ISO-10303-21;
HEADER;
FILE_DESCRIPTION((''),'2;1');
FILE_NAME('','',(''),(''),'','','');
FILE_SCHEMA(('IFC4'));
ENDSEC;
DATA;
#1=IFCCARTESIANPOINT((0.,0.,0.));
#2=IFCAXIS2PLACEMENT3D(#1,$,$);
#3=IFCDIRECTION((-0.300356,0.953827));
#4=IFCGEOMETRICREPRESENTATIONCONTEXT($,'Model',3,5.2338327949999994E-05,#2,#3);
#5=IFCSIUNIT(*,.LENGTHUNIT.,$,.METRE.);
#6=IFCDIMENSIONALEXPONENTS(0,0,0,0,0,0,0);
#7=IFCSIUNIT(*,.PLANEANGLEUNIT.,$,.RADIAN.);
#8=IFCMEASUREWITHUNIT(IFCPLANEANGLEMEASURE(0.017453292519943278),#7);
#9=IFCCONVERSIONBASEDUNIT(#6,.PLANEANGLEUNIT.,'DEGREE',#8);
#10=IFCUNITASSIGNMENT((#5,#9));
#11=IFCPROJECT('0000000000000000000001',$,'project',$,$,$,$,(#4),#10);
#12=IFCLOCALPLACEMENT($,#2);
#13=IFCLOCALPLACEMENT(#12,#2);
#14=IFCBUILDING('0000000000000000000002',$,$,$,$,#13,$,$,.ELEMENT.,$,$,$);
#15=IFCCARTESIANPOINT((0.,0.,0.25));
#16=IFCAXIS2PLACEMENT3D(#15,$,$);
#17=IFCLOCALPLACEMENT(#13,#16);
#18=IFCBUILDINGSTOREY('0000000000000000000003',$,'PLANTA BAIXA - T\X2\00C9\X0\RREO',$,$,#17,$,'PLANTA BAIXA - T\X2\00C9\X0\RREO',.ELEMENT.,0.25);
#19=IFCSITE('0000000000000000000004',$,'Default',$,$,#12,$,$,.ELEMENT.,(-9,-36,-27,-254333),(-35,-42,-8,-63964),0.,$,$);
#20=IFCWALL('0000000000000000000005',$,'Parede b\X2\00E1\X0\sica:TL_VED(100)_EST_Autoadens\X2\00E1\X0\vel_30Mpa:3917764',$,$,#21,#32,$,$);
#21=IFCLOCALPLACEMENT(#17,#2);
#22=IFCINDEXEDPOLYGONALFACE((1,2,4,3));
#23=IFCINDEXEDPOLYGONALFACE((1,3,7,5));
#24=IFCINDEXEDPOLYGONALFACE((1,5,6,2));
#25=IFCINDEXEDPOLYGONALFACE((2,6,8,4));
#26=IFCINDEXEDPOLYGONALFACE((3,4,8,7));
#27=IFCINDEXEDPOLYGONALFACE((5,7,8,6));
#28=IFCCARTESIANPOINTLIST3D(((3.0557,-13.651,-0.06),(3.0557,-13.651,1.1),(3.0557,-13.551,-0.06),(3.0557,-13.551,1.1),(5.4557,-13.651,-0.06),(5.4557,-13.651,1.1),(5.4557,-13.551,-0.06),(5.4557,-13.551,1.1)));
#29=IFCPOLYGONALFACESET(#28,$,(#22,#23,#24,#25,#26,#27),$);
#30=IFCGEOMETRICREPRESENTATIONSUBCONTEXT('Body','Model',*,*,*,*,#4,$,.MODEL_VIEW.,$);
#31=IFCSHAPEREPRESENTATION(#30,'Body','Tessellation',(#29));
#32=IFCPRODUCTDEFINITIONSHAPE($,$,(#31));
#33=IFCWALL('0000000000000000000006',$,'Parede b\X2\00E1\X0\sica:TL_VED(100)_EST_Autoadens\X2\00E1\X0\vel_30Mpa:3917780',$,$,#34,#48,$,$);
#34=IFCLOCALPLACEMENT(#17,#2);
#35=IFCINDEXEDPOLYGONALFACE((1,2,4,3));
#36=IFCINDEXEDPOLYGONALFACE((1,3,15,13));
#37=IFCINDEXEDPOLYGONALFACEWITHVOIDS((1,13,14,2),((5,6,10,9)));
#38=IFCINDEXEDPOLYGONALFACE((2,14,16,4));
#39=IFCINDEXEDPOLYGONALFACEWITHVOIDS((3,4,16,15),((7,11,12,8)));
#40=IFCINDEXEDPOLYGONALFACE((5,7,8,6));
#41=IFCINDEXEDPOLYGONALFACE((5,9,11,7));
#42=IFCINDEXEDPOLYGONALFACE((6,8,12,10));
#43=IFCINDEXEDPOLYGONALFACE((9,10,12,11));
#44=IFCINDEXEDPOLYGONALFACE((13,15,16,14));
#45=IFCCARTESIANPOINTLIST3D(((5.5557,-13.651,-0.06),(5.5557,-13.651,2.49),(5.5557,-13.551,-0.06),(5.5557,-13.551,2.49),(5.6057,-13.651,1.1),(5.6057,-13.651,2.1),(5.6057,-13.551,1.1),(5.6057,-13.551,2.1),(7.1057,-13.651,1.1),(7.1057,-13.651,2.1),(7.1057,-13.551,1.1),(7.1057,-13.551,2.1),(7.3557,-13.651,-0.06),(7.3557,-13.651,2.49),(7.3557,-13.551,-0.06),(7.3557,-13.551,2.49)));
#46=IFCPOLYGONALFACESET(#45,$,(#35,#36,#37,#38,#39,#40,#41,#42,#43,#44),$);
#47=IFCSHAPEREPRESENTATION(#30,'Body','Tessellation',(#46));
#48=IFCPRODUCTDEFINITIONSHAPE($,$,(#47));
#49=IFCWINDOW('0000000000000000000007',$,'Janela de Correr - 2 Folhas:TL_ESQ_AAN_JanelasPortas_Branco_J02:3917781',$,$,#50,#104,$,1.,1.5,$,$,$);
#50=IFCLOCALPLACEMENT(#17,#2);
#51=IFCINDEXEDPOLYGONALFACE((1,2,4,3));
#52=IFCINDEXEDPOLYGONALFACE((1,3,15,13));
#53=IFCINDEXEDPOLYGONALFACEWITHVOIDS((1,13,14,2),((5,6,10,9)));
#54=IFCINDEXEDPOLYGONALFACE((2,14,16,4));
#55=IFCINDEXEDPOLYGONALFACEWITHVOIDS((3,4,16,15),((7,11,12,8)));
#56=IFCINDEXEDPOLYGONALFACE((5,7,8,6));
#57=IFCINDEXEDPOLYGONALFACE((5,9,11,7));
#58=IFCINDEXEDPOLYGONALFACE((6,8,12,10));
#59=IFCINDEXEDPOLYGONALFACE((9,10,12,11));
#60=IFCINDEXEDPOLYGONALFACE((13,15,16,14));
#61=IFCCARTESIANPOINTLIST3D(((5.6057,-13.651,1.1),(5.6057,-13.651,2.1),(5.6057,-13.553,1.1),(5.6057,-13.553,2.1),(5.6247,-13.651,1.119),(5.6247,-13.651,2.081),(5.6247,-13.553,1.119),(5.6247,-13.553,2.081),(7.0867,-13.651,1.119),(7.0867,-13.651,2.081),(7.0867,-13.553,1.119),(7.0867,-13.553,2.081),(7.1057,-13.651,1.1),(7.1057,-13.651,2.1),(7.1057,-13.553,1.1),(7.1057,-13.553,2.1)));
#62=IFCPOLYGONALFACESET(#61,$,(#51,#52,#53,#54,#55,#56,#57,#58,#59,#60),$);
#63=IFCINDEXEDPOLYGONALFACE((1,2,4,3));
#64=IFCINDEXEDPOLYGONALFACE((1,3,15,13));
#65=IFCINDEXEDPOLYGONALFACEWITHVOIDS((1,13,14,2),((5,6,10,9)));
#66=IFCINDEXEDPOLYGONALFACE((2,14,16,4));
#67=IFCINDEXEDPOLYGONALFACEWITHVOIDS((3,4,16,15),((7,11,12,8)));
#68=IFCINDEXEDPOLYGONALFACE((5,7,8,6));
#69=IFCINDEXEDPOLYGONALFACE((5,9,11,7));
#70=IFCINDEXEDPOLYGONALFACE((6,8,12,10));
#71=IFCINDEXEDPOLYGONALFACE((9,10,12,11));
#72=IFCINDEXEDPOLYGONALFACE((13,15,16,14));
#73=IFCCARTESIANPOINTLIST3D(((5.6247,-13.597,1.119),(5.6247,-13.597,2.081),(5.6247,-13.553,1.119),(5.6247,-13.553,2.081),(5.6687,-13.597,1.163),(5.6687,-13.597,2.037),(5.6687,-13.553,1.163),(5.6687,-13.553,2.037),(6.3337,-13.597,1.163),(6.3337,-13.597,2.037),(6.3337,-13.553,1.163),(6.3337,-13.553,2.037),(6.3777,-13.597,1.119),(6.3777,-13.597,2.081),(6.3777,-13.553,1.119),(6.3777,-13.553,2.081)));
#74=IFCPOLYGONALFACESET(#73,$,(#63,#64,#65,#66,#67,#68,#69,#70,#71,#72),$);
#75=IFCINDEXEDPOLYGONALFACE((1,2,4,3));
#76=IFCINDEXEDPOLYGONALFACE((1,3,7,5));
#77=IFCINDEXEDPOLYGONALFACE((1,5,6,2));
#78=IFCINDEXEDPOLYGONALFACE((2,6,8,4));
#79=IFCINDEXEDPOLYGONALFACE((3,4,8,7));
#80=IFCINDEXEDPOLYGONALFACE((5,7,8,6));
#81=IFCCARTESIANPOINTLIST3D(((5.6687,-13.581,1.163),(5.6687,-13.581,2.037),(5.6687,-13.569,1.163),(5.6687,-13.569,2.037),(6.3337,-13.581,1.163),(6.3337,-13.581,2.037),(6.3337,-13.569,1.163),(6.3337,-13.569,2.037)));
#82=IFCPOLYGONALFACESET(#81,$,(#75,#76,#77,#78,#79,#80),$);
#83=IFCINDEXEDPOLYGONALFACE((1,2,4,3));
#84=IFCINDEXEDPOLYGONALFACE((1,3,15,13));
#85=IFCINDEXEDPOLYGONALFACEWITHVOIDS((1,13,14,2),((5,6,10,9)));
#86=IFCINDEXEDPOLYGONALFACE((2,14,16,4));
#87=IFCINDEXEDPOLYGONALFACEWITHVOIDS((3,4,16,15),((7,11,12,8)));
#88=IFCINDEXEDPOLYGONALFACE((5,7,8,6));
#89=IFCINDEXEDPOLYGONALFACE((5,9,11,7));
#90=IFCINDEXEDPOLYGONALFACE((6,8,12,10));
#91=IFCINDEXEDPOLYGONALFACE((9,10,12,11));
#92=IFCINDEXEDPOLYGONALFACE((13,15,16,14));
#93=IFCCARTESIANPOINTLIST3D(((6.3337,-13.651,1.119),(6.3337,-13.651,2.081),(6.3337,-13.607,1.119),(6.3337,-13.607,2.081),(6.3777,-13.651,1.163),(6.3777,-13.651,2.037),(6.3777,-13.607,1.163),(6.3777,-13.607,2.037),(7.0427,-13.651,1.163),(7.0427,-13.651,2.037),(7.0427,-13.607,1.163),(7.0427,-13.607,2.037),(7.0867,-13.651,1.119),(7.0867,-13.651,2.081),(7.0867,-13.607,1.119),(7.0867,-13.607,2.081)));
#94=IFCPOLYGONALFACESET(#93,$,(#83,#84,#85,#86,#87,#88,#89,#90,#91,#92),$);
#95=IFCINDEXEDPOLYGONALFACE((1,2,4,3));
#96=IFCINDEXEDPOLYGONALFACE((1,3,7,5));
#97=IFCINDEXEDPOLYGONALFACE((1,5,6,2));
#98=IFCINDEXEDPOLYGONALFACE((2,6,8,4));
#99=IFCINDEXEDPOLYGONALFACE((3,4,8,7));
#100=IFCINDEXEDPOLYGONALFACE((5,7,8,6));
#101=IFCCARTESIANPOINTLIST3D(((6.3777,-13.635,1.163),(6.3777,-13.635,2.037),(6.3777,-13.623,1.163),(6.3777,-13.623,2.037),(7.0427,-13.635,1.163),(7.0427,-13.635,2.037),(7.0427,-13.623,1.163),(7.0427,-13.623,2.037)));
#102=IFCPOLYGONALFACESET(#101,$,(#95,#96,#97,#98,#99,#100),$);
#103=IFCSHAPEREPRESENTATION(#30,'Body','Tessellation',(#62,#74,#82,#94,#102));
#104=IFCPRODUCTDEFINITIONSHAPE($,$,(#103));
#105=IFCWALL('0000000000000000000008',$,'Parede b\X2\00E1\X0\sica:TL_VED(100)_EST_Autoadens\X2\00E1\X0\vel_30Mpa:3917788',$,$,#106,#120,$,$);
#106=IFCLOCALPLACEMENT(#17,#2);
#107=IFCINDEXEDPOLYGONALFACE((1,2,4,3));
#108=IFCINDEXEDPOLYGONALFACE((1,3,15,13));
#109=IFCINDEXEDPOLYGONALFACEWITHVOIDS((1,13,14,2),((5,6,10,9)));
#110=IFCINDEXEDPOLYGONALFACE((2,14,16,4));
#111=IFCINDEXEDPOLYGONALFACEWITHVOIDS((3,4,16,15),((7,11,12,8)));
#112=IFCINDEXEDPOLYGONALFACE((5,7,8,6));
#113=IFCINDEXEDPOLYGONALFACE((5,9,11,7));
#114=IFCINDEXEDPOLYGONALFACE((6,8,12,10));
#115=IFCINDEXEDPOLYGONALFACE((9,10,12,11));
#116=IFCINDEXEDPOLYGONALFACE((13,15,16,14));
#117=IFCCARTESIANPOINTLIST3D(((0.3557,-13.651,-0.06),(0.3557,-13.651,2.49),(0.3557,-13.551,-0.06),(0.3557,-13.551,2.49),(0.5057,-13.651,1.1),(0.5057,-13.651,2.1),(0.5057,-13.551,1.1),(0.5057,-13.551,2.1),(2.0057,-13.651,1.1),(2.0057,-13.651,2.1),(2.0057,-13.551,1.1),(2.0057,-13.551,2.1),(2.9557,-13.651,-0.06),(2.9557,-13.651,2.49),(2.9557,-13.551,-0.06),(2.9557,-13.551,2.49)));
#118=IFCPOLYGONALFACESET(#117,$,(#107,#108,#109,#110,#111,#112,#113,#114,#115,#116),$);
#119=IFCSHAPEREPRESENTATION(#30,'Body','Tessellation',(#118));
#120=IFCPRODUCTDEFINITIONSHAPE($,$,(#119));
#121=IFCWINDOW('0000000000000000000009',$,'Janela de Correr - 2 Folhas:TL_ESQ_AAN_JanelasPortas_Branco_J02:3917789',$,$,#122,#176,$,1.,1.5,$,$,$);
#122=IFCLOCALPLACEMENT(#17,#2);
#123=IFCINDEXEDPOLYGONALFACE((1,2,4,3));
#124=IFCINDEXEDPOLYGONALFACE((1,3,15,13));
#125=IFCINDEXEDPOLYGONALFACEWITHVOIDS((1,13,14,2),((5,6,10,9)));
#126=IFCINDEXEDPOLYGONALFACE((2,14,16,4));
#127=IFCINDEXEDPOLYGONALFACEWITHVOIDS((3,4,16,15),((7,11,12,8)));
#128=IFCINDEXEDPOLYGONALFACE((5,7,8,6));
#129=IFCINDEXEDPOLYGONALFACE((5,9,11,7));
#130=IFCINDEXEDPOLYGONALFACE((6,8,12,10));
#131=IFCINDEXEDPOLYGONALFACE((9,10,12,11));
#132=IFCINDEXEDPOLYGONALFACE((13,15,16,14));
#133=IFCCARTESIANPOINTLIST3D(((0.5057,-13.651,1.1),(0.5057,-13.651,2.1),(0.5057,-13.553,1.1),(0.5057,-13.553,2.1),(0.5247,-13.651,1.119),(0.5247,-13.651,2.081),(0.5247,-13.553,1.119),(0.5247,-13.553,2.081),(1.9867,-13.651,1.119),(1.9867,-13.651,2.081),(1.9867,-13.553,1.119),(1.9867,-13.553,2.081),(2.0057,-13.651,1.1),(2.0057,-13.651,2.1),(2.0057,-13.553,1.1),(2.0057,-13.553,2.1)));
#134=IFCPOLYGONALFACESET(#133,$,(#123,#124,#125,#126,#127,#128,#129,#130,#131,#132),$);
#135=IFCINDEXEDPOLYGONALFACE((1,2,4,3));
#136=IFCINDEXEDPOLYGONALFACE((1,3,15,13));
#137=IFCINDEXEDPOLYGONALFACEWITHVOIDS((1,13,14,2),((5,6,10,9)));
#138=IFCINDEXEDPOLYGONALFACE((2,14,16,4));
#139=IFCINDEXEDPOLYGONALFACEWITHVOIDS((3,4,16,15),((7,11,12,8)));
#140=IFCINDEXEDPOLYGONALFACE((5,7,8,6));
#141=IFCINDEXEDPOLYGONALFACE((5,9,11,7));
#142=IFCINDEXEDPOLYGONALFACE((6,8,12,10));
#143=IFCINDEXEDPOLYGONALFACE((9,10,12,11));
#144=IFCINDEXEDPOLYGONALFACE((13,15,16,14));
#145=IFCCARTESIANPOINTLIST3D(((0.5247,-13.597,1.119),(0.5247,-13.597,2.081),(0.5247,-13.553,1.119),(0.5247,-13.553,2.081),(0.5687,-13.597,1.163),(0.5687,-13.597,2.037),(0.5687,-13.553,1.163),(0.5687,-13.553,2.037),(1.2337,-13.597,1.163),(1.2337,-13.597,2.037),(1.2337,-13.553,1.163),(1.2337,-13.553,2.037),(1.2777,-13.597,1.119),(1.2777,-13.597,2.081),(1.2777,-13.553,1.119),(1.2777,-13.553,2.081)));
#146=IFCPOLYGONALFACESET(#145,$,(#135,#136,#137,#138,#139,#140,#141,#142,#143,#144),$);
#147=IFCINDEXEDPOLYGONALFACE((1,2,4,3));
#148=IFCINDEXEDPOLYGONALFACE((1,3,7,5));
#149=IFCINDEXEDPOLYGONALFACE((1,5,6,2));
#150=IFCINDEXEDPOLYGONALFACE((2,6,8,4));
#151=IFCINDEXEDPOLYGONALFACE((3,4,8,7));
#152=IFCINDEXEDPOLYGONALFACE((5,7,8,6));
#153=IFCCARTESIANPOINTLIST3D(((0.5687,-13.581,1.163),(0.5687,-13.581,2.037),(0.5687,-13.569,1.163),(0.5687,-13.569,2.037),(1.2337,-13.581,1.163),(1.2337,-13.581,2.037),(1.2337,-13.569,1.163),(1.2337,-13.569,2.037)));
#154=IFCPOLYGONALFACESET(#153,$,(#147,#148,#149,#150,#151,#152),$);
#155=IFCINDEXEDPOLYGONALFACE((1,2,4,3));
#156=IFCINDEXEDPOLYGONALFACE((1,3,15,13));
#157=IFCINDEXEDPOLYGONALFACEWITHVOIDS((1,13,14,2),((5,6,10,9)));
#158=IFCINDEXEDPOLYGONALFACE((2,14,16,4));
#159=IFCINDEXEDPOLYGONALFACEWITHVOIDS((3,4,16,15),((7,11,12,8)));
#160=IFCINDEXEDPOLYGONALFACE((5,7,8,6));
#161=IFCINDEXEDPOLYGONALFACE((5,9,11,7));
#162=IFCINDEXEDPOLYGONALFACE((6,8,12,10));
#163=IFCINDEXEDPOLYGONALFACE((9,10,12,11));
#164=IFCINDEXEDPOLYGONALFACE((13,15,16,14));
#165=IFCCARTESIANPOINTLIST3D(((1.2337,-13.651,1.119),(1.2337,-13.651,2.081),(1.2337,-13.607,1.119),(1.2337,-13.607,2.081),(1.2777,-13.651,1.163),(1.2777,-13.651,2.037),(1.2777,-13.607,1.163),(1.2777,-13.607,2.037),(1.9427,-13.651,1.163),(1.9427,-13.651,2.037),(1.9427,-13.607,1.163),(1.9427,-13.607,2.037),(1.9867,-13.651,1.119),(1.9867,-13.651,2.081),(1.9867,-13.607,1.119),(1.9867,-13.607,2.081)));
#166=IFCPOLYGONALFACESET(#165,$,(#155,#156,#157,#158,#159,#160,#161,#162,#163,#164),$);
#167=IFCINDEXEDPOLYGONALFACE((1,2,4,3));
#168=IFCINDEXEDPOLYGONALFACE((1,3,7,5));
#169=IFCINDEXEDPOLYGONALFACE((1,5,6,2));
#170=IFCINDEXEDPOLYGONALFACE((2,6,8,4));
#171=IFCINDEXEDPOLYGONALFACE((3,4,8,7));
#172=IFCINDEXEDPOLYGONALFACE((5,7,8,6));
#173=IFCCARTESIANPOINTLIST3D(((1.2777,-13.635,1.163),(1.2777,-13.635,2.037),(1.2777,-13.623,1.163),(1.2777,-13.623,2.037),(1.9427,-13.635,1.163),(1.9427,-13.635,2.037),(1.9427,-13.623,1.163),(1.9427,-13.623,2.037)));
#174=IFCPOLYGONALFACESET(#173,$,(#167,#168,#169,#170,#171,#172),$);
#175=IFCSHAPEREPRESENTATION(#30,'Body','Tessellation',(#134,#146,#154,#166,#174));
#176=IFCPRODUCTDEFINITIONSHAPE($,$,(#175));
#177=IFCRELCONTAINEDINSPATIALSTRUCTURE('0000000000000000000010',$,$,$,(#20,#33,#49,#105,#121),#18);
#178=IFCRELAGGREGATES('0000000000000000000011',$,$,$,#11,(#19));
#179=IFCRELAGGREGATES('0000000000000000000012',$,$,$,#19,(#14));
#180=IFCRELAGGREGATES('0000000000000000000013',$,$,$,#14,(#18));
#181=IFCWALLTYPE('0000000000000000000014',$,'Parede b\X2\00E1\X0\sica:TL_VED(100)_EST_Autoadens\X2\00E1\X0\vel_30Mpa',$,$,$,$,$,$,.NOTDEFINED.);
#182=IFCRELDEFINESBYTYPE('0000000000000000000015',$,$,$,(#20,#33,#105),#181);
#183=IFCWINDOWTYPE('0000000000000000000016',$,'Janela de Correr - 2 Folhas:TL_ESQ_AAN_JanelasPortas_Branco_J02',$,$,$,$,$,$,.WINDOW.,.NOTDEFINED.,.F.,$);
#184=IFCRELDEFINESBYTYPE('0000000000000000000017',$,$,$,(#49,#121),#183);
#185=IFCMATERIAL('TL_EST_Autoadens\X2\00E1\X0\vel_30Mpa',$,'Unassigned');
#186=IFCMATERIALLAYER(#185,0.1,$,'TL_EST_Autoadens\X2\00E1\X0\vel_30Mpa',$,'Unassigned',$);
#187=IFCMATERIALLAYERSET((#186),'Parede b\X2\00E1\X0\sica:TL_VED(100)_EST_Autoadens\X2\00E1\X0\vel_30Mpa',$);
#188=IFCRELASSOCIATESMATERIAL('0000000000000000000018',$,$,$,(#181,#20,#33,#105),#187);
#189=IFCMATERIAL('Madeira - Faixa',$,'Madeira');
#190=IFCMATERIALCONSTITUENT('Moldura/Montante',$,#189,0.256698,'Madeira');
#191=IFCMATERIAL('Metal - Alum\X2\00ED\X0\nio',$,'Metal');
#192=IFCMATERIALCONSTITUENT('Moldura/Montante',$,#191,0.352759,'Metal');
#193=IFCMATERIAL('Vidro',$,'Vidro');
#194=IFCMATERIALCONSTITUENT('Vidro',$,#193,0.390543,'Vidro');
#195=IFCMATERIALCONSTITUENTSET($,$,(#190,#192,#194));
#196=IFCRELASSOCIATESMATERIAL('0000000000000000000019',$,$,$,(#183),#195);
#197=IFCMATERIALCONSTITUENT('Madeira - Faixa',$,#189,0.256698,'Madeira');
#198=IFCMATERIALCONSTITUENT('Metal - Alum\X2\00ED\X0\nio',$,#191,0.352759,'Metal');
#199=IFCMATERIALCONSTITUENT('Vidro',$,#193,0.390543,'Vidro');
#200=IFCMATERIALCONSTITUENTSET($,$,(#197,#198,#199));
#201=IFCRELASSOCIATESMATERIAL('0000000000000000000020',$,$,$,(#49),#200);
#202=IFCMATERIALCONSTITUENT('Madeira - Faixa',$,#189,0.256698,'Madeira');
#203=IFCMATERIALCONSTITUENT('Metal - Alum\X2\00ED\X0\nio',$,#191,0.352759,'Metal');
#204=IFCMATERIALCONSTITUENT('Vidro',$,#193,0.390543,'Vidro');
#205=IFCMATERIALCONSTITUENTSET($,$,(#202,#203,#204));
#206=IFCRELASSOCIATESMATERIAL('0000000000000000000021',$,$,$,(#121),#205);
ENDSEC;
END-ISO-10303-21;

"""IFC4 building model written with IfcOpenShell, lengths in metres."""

from ifc_helpers import new_model, entity, si_unit, converted_unit, direction, frame, frame_2d, origin, origin_2d_with_axis, place, context, subcontext, project, spatial, polyline, rectangle, outline, extrude, source, transform, mapped, material, layer, layer_set, layer_usage, constituent, constituent_set, type_object, type_shapes, element, fill, save


model = new_model("IFC4")

# Units and contexts
model_context = context("Model", 3, precision=5.2338327949999994e-05, world=origin(), true_north=direction((-0.300356, 0.953827)))
body_context = subcontext(model_context, "Body", "Model", "MODEL_VIEW")
ifc_project = project(units=[si_unit("LENGTHUNIT", "METRE"), converted_unit("PLANEANGLEUNIT", "DEGREE", entity("IfcPlaneAngleMeasure", 0.017453292519943278), si_unit("PLANEANGLEUNIT", "RADIAN"), dimensions=[0, 0, 0, 0, 0, 0, 0])], contexts=[model_context])

# Site, building, storey
site_placement = place(None, origin())
site = spatial("IfcSite", under=ifc_project, at=site_placement, Name="Default", CompositionType="ELEMENT", RefLatitude=(-9, -36, -27, -254333), RefLongitude=(-35, -42, -8, -63964), RefElevation=0.0)
building_placement = place(site_placement, origin())
building = spatial("IfcBuilding", under=site, at=building_placement, CompositionType="ELEMENT")
storey_placement = place(building_placement, frame((0.0, 0.0, 0.25)))
storey = spatial("IfcBuildingStorey", under=building, at=storey_placement, Name="PLANTA BAIXA - TÉRREO", LongName="PLANTA BAIXA - TÉRREO", CompositionType="ELEMENT", Elevation=0.25)

# Wall
ifc_material_1 = material(Name="TL_EST_Autoadensável_30Mpa", Category="Unassigned")
ifc_layer_1 = layer(ifc_material_1, 0.1, Name="TL_EST_Autoadensável_30Mpa", Category="Unassigned")
ifc_layer_set_1 = layer_set([ifc_layer_1], Name="Parede básica:TL_VED(100)_EST_Autoadensável_30Mpa")
ifc_layer_usage_1 = layer_usage(ifc_layer_set_1, "AXIS2", "NEGATIVE", 0.05)
wall_type_1 = type_object("IfcWallType", Name="Parede básica:TL_VED(100)_EST_Autoadensável_30Mpa", PredefinedType="NOTDEFINED", material=ifc_layer_set_1)
wall_1_placement = place(storey_placement, frame((3.0557, -13.601, -0.06)))
element("IfcWall", 1, at=wall_1_placement, inside=storey, type_object=wall_type_1, material=ifc_layer_usage_1, Name="Parede básica:TL_VED(100)_EST_Autoadensável_30Mpa:3917764", context=body_context, shape_type="SweptSolid", body=[
    extrude(rectangle(XDim=2.4, YDim=0.1, at=frame_2d((1.2, 0.0), x_axis=(-1.0, 0.0))), origin(), (0.0, 0.0, 1.0), 1.16),
])

# Walls, openings, windows
ifc_layer_usage_2 = layer_usage(ifc_layer_set_1, "AXIS2", "NEGATIVE", 0.05)
wall_2_placement = place(storey_placement, frame((5.5557, -13.601, -0.06)))
wall_2 = element("IfcWall", 2, at=wall_2_placement, inside=storey, type_object=wall_type_1, material=ifc_layer_usage_2, Name="Parede básica:TL_VED(100)_EST_Autoadensável_30Mpa:3917780", context=body_context, shape_type="SweptSolid", body=[
    extrude(rectangle(XDim=1.8, YDim=0.1, at=frame_2d((0.9, 0.0), x_axis=(-1.0, 0.0))), origin(), (0.0, 0.0, 1.0), 2.55),
])
opening_1_placement = place(wall_2_placement, frame((0.05, -0.05, 1.16)))
opening_1 = element("IfcOpeningElement", 3, at=opening_1_placement, cuts=wall_2, PredefinedType="OPENING", context=body_context, shape_type="SweptSolid", body=[
    extrude(rectangle(XDim=1.0, YDim=1.5, at=frame_2d((0.5, 0.75), x_axis=(-1.0, 0.0))), frame((0.0, 0.0, 0.0), z_axis=(0.0, 1.0, 0.0), x_axis=(0.0, 0.0, 1.0)), (0.0, 0.0, 1.0), 0.1),
])
ifc_material_2 = material(Name="Madeira - Faixa", Category="Madeira")
ifc_constituent_1 = constituent(ifc_material_2, Name="Madeira - Faixa", Category="Madeira", fraction=0.256698)
ifc_material_3 = material(Name="Metal - Alumínio", Category="Metal")
ifc_constituent_2 = constituent(ifc_material_3, Name="Metal - Alumínio", Category="Metal", fraction=0.352759)
ifc_material_4 = material(Name="Vidro", Category="Vidro")
ifc_constituent_3 = constituent(ifc_material_4, Name="Vidro", Category="Vidro", fraction=0.390543)
ifc_constituent_set_1 = constituent_set(constituents=[ifc_constituent_1, ifc_constituent_2, ifc_constituent_3])
ifc_constituent_4 = constituent(ifc_material_2, Name="Moldura/Montante", Category="Madeira", fraction=0.256698)
ifc_constituent_5 = constituent(ifc_material_3, Name="Moldura/Montante", Category="Metal", fraction=0.352759)
ifc_constituent_6 = constituent(ifc_material_4, Name="Vidro", Category="Vidro", fraction=0.390543)
ifc_constituent_set_2 = constituent_set(constituents=[ifc_constituent_4, ifc_constituent_5, ifc_constituent_6])
window_type = type_object("IfcWindowType", Name="Janela de Correr - 2 Folhas:TL_ESQ_AAN_JanelasPortas_Branco_J02", ParameterTakesPrecedence=False, PartitioningType="NOTDEFINED", PredefinedType="WINDOW", material=ifc_constituent_set_2)
shared_shape_1 = source(origin(), body_context, "Body", "SweptSolid", [
    extrude(outline(polyline([(-0.75, -0.5), (0.75, -0.5), (0.75, 0.5), (-0.75, 0.5), (-0.75, -0.5)]), holes=[polyline([(-0.731, -0.481), (-0.731, 0.481), (0.731, 0.481), (0.731, -0.481), (-0.731, -0.481)])]), frame((0.75, 0.124, 0.5), z_axis=(0.0, -1.0, 0.0), x_axis=(-1.0, 0.0, 0.0)), (0.0, 0.0, 1.0), 0.098),
    extrude(outline(polyline([(-0.3765, -0.481), (0.3765, -0.481), (0.3765, 0.481), (-0.3765, 0.481), (-0.3765, -0.481)]), holes=[polyline([(-0.3325, -0.437), (-0.3325, 0.437), (0.3325, 0.437), (0.3325, -0.437), (-0.3325, -0.437)])]), frame((0.3955, 0.124, 0.5), z_axis=(0.0, -1.0, 0.0), x_axis=(-1.0, 0.0, 0.0)), (0.0, 0.0, 1.0), 0.044),
    extrude(rectangle(XDim=0.665, YDim=0.012, at=origin_2d_with_axis()), frame((0.3955, 0.102, 0.063), z_axis=(0.0, 0.0, 1.0), x_axis=(-1.0, 0.0, 0.0)), (0.0, 0.0, 1.0), 0.874),
    extrude(outline(polyline([(-0.481, -0.3765), (0.481, -0.3765), (0.481, 0.3765), (-0.481, 0.3765), (-0.481, -0.3765)]), holes=[polyline([(-0.437, -0.3325), (-0.437, 0.3325), (0.437, 0.3325), (0.437, -0.3325), (-0.437, -0.3325)])]), frame((1.1045, 0.07, 0.5), z_axis=(0.0, -1.0, 0.0), x_axis=(0.0, 0.0, -1.0)), (0.0, 0.0, 1.0), 0.044),
    extrude(rectangle(XDim=0.665, YDim=0.012, at=origin_2d_with_axis()), frame((1.1045, 0.048, 0.063), z_axis=(0.0, 0.0, 1.0), x_axis=(-1.0, 0.0, 0.0)), (0.0, 0.0, 1.0), 0.874),
])
type_shapes(window_type, [shared_shape_1])
window_1_placement = place(opening_1_placement, frame((0.0, -0.026, 0.0)))
window_1 = element("IfcWindow", 4, at=window_1_placement, inside=storey, type_object=window_type, material=ifc_constituent_set_1, Name="Janela de Correr - 2 Folhas:TL_ESQ_AAN_JanelasPortas_Branco_J02:3917781", OverallHeight=1.0, OverallWidth=1.5, context=body_context, shape_type="MappedRepresentation", body=[
    mapped(shared_shape_1, transform((0.0, 0.0, 0.0), scale=1.0)),
])
fill(opening_1, window_1)
ifc_layer_usage_3 = layer_usage(ifc_layer_set_1, "AXIS2", "NEGATIVE", 0.05)
wall_3_placement = place(storey_placement, frame((0.3557, -13.601, -0.06)))
wall_3 = element("IfcWall", 5, at=wall_3_placement, inside=storey, type_object=wall_type_1, material=ifc_layer_usage_3, Name="Parede básica:TL_VED(100)_EST_Autoadensável_30Mpa:3917788", context=body_context, shape_type="SweptSolid", body=[
    extrude(rectangle(XDim=2.6, YDim=0.1, at=frame_2d((1.3, 0.0), x_axis=(-1.0, 0.0))), origin(), (0.0, 0.0, 1.0), 2.55),
])
opening_2_placement = place(wall_3_placement, frame((0.15, -0.05, 1.16)))
opening_2 = element("IfcOpeningElement", 6, at=opening_2_placement, cuts=wall_3, PredefinedType="OPENING", context=body_context, shape_type="SweptSolid", body=[
    extrude(rectangle(XDim=1.0, YDim=1.5, at=frame_2d((0.5, 0.75), x_axis=(-1.0, 0.0))), frame((0.0, 0.0, 0.0), z_axis=(0.0, 1.0, 0.0), x_axis=(0.0, 0.0, 1.0)), (0.0, 0.0, 1.0), 0.1),
])
ifc_constituent_7 = constituent(ifc_material_2, Name="Madeira - Faixa", Category="Madeira", fraction=0.256698)
ifc_constituent_8 = constituent(ifc_material_3, Name="Metal - Alumínio", Category="Metal", fraction=0.352759)
ifc_constituent_9 = constituent(ifc_material_4, Name="Vidro", Category="Vidro", fraction=0.390543)
ifc_constituent_set_3 = constituent_set(constituents=[ifc_constituent_7, ifc_constituent_8, ifc_constituent_9])
window_2_placement = place(opening_2_placement, frame((0.0, -0.026, 0.0)))
window_2 = element("IfcWindow", 7, at=window_2_placement, inside=storey, type_object=window_type, material=ifc_constituent_set_3, Name="Janela de Correr - 2 Folhas:TL_ESQ_AAN_JanelasPortas_Branco_J02:3917789", OverallHeight=1.0, OverallWidth=1.5, context=body_context, shape_type="MappedRepresentation", body=[
    mapped(shared_shape_1, transform((0.0, 0.0, 0.0), scale=1.0)),
])
fill(opening_2, window_2)

save(model, "model.ifc")
